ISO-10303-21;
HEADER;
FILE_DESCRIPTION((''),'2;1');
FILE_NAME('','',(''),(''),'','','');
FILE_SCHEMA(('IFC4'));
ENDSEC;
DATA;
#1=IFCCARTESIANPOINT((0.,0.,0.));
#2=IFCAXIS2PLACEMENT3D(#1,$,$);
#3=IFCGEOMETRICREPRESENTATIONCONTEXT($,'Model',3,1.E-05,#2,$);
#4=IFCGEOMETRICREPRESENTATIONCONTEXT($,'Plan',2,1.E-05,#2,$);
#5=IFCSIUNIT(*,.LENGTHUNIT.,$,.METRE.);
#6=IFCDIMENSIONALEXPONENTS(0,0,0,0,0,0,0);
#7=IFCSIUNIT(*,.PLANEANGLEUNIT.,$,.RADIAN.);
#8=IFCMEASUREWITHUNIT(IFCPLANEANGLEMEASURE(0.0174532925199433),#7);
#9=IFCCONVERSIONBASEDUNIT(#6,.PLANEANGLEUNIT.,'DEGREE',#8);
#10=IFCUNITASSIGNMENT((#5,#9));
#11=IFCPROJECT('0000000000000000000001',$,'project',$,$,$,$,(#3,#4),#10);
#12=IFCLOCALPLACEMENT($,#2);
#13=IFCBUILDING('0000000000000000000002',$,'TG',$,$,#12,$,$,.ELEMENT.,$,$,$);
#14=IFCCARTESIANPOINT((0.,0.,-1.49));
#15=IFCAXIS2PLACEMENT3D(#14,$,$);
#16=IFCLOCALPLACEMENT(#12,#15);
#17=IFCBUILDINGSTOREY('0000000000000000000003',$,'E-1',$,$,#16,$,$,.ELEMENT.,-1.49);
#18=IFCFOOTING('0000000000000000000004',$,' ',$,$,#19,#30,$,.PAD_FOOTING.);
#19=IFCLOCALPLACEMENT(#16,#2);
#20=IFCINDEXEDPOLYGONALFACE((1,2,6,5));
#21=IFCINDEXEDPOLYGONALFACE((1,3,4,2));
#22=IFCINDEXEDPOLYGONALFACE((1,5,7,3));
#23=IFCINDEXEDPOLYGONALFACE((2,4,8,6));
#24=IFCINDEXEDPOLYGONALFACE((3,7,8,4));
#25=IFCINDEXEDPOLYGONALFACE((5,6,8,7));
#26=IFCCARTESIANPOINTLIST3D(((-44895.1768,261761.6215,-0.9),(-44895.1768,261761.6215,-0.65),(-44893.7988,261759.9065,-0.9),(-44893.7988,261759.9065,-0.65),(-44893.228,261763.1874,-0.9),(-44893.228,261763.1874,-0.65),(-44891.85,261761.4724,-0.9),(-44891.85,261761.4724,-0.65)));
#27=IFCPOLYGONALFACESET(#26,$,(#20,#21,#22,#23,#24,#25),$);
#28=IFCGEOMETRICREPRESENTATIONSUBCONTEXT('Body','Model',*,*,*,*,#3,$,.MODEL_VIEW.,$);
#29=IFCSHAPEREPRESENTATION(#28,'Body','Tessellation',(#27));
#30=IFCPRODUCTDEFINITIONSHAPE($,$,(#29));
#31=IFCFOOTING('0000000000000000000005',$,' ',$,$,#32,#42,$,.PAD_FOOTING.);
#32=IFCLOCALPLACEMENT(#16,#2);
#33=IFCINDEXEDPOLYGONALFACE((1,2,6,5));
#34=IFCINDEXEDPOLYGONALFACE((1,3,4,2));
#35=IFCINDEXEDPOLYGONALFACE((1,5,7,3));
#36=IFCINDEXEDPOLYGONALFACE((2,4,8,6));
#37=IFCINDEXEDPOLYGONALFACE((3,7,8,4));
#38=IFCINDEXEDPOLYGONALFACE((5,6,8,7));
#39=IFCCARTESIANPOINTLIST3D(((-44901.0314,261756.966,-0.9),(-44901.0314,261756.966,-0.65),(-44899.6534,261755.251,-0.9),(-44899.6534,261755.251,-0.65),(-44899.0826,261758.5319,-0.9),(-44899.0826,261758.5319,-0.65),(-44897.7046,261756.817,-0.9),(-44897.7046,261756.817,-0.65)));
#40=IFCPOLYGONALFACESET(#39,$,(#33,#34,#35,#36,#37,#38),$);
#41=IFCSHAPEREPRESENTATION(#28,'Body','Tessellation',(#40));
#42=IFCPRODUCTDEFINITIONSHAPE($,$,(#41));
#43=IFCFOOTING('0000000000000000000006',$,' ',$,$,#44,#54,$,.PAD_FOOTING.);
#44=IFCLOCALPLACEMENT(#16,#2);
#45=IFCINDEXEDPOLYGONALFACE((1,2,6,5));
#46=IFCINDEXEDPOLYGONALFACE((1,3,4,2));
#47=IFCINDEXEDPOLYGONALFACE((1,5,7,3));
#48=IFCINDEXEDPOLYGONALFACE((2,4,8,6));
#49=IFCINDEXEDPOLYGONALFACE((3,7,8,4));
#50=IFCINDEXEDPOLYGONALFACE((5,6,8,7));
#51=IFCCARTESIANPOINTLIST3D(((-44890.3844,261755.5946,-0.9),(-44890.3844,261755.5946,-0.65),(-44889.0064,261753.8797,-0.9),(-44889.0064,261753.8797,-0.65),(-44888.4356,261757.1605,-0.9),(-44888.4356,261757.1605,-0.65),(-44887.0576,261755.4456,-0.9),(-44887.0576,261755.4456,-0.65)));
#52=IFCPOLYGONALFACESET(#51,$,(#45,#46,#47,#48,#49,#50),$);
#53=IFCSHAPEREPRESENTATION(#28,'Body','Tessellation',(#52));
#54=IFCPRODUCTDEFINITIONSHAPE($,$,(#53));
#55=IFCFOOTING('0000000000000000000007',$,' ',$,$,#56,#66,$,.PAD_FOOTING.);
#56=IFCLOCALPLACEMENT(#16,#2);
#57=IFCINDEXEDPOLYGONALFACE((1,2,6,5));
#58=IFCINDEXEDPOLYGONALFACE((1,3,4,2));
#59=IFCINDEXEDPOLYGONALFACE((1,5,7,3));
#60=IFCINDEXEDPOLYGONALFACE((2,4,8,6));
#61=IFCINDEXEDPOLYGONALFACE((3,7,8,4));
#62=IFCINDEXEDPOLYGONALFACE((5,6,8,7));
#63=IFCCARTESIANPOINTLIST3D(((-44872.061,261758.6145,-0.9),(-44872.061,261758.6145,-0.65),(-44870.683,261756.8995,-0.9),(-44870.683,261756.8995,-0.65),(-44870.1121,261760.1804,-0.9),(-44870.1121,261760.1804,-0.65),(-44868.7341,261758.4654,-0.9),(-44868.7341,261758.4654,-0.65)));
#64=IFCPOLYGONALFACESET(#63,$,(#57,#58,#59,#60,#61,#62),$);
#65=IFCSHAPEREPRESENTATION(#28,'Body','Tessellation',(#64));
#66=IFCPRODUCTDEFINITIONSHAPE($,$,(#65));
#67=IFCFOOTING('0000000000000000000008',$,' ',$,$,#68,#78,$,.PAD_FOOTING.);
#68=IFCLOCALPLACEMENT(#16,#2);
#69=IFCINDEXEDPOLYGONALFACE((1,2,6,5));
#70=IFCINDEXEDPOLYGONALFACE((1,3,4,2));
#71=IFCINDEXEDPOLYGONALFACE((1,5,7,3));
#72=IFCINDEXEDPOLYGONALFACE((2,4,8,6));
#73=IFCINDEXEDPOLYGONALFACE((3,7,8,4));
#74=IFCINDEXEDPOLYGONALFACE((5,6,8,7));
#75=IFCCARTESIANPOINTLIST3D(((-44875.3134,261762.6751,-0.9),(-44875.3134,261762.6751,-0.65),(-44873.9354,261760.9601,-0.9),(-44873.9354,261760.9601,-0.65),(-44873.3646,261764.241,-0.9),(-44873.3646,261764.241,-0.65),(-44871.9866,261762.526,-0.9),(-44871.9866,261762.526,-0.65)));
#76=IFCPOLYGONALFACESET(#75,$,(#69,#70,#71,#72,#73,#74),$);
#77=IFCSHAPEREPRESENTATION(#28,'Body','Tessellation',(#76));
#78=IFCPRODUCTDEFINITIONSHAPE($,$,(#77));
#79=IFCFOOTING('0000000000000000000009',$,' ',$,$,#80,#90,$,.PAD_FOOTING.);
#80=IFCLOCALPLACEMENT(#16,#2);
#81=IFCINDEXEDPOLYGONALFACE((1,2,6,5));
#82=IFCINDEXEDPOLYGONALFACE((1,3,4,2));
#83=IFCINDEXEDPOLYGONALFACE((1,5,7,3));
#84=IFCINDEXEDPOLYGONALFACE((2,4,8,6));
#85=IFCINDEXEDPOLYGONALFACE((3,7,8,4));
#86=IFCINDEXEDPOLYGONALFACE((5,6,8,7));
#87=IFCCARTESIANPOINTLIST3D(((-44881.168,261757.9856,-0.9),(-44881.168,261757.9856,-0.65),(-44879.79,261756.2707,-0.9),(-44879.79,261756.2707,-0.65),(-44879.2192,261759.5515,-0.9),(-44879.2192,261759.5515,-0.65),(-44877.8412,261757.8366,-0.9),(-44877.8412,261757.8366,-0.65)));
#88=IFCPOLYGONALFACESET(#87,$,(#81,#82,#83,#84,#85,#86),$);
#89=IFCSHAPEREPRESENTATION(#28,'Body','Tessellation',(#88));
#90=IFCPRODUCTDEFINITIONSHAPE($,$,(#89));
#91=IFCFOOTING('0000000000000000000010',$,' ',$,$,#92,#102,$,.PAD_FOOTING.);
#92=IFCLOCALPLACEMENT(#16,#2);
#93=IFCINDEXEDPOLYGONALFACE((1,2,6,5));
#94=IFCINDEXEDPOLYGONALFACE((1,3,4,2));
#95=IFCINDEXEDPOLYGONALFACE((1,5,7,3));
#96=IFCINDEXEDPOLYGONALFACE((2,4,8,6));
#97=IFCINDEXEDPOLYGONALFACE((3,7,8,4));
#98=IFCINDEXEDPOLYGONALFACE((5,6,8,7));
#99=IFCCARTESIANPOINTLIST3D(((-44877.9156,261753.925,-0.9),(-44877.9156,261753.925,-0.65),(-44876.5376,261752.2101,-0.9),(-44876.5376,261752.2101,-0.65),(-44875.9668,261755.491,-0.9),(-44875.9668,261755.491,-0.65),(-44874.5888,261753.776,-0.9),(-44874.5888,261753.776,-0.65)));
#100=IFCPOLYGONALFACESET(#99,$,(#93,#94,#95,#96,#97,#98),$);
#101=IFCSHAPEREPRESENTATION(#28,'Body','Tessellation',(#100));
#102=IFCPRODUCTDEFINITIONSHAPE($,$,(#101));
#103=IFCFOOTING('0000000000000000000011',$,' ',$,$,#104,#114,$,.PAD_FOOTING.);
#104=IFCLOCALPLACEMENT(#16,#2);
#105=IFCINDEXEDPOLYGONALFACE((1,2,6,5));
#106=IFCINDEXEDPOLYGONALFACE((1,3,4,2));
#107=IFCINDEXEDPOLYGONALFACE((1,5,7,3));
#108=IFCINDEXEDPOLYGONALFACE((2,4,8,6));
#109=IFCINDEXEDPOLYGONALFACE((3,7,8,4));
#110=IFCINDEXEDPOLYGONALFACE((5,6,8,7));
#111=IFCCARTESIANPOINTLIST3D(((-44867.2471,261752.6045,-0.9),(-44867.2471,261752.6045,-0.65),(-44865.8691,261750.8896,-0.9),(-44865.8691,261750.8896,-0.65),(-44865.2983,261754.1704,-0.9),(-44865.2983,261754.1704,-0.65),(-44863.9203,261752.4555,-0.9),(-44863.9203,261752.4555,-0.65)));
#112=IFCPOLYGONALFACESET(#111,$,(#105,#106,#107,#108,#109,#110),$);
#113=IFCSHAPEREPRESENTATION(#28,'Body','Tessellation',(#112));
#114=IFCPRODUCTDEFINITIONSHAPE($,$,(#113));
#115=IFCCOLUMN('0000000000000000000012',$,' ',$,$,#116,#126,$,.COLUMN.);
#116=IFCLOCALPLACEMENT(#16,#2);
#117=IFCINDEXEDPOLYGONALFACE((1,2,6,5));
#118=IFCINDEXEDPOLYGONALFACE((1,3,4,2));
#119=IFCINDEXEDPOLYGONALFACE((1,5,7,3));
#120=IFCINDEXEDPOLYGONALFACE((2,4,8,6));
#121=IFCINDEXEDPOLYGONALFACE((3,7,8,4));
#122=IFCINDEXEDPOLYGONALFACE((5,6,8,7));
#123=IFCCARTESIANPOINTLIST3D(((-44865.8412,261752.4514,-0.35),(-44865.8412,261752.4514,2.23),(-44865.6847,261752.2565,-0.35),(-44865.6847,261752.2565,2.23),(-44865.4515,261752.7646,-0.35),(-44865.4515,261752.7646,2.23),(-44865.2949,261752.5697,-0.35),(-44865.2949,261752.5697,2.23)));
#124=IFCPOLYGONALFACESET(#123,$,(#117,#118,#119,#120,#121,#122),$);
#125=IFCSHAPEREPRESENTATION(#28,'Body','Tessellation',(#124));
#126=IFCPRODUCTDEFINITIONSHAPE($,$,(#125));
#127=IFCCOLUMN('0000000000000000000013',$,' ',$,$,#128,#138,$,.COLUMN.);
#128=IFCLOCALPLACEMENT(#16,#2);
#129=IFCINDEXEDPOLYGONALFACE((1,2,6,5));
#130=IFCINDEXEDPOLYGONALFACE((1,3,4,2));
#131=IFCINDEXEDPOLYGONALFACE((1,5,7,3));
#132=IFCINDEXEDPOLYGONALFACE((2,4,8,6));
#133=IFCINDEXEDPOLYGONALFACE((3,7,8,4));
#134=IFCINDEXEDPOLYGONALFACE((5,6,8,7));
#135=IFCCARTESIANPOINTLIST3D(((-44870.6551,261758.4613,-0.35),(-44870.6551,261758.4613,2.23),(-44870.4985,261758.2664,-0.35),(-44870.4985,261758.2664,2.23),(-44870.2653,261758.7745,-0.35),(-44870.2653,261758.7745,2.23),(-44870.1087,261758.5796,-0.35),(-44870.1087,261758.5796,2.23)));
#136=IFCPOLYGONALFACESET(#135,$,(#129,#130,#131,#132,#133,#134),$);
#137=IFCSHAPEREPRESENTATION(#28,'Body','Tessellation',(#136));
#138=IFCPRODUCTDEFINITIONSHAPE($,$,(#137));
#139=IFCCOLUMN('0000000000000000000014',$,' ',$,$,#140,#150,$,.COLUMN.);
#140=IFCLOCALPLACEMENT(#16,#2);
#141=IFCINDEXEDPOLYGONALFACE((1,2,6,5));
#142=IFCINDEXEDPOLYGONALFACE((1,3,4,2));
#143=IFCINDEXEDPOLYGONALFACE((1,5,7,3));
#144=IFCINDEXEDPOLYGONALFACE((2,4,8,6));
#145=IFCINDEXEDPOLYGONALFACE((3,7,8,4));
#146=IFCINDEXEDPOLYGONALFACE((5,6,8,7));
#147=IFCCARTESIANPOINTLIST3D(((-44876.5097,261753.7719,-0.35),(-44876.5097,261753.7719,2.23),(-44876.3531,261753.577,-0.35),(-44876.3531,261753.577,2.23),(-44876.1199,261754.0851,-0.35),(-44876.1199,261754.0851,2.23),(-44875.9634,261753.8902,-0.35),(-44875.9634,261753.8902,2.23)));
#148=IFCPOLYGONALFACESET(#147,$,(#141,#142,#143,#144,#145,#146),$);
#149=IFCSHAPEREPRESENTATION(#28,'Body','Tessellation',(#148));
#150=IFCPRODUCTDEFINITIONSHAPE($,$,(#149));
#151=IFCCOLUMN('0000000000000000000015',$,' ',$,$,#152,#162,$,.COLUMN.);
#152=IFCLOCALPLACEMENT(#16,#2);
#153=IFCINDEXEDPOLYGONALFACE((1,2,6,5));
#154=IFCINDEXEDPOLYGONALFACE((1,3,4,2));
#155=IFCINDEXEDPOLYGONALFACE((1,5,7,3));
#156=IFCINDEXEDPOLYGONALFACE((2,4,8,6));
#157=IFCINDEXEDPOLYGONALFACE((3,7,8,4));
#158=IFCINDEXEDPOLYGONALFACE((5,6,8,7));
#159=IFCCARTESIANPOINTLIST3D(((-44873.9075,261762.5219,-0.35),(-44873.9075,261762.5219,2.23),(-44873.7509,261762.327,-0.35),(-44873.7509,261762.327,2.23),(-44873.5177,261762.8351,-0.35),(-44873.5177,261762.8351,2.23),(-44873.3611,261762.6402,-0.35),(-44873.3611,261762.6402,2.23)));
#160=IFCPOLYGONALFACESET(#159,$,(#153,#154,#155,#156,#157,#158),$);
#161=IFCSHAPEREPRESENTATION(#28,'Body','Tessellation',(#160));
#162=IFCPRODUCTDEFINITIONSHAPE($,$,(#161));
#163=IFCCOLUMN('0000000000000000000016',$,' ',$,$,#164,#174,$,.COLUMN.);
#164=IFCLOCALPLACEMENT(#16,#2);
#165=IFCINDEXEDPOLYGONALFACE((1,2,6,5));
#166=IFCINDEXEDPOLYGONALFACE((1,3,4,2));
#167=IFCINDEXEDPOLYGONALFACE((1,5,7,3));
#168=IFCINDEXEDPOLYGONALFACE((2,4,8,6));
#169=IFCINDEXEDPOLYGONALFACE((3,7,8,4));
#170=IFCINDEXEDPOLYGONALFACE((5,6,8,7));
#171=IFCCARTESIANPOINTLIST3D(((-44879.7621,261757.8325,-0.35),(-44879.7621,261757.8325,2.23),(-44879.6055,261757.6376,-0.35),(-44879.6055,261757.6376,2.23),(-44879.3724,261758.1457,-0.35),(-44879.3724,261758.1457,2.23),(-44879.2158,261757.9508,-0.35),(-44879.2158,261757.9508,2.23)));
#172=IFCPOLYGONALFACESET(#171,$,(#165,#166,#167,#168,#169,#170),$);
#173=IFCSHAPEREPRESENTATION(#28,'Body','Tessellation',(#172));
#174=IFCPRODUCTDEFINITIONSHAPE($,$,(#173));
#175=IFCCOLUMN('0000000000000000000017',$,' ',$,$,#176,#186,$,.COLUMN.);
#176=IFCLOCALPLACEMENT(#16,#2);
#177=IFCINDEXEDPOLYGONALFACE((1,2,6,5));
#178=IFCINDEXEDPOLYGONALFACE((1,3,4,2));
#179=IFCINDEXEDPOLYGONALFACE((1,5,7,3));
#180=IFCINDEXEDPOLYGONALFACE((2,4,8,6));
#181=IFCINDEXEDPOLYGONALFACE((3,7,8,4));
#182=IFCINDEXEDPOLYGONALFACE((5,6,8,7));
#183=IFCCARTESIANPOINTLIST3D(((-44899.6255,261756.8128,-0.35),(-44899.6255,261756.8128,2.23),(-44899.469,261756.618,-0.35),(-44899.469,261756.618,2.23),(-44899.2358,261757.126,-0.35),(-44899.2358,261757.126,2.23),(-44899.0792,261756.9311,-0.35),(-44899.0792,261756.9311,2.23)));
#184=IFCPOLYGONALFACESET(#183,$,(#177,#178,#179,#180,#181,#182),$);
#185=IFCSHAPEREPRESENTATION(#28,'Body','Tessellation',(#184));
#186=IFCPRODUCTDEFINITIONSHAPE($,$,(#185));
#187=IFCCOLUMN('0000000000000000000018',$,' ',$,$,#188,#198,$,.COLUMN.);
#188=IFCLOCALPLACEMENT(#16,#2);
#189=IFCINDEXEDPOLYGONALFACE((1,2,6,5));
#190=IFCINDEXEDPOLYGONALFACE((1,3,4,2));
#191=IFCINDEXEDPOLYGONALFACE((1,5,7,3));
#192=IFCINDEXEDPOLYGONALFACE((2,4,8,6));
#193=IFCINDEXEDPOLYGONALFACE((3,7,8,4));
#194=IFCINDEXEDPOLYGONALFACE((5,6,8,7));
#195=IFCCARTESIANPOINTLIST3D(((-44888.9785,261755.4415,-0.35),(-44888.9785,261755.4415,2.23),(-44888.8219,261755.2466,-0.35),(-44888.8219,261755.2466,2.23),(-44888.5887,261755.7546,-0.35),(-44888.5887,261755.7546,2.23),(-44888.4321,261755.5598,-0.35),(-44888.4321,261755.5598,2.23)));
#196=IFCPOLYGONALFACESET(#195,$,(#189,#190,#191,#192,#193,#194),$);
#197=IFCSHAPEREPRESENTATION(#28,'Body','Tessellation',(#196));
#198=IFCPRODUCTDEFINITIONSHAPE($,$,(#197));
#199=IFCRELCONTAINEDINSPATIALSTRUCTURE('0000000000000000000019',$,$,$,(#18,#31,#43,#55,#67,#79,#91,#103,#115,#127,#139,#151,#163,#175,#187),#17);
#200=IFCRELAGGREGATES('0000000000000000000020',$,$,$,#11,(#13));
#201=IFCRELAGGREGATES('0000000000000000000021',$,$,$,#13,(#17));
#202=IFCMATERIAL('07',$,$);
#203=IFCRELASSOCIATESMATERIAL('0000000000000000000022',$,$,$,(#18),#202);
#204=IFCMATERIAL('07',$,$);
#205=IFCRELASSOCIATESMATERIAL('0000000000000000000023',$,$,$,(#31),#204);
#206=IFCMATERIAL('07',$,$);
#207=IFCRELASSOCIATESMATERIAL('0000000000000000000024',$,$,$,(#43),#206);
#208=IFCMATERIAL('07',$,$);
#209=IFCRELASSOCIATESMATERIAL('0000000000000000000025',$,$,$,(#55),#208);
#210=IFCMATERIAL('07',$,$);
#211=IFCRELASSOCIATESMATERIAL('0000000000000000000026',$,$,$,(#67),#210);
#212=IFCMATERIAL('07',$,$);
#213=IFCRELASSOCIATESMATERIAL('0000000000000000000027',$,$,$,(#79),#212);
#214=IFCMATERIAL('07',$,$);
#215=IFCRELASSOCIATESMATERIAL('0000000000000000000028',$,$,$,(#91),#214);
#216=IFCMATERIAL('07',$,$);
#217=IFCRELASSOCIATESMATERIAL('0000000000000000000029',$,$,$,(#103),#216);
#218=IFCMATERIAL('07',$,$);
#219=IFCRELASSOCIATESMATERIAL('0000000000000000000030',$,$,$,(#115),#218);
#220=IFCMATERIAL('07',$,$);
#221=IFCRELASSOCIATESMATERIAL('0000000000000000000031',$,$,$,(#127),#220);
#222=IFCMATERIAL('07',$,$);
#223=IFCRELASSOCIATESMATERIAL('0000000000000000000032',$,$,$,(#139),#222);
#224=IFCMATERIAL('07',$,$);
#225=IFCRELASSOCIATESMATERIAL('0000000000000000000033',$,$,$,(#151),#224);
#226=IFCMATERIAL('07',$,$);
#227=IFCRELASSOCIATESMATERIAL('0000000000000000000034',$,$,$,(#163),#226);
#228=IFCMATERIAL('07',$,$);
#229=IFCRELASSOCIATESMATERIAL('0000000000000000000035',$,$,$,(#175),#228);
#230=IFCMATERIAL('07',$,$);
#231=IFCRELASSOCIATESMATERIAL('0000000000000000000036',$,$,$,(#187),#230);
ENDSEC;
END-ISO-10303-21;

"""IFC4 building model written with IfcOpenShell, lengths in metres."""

from ifc_helpers import new_model, entity, si_unit, converted_unit, frame, frame_2d, origin, origin_with_axes, place, context, subcontext, project, spatial, rectangle, extrude, material, element, save


model = new_model("IFC4")

# Units and contexts
model_context = context("Model", 3, precision=1e-05, world=origin())
plan_context = context("Plan", 2, precision=1e-05, world=origin())
body_context = subcontext(model_context, "Body", "Model", "MODEL_VIEW")
ifc_project = project(units=[si_unit("LENGTHUNIT", "METRE"), converted_unit("PLANEANGLEUNIT", "DEGREE", entity("IfcPlaneAngleMeasure", 0.0174532925199433), si_unit("PLANEANGLEUNIT", "RADIAN"), dimensions=[0, 0, 0, 0, 0, 0, 0])], contexts=[model_context, plan_context])

# Building, storey
building_placement = place(None, origin())
building = spatial("IfcBuilding", under=ifc_project, at=building_placement, Name="TG", CompositionType="ELEMENT")
storey_placement = place(building_placement, frame((0.0, 0.0, -1.49)))
storey = spatial("IfcBuildingStorey", under=building, at=storey_placement, Name="E-1", CompositionType="ELEMENT", Elevation=-1.49)

# Footings
ifc_material_1 = material(Name="07")
footing_1_placement = place(storey_placement, frame((-44895.1768, 261759.9065, -0.9)))
element("IfcFooting", 1, at=footing_1_placement, inside=storey, material=ifc_material_1, Name=" ", PredefinedType="PAD_FOOTING", context=body_context, shape_type="SweptSolid", body=[
    extrude(rectangle(XDim=2.5, YDim=2.2, at=frame_2d((0.2854, 1.6404), x_axis=(0.779531, 0.626364))), frame((1.378, 0.0, 0.0), z_axis=(0.0, 0.0, 1.0), x_axis=(1.0, 0.0, 0.0)), (0.0, 0.0, 1.0), 0.25),
])
ifc_material_2 = material(Name="07")
footing_2_placement = place(storey_placement, frame((-44901.0314, 261755.251, -0.9)))
element("IfcFooting", 2, at=footing_2_placement, inside=storey, material=ifc_material_2, Name=" ", PredefinedType="PAD_FOOTING", context=body_context, shape_type="SweptSolid", body=[
    extrude(rectangle(XDim=2.5, YDim=2.2, at=frame_2d((0.2854, 1.6404), x_axis=(0.779531, 0.626364))), frame((1.378, 0.0, 0.0), z_axis=(0.0, 0.0, 1.0), x_axis=(1.0, 0.0, 0.0)), (0.0, 0.0, 1.0), 0.25),
])
ifc_material_3 = material(Name="07")
footing_3_placement = place(storey_placement, frame((-44890.3844, 261753.8797, -0.9)))
element("IfcFooting", 3, at=footing_3_placement, inside=storey, material=ifc_material_3, Name=" ", PredefinedType="PAD_FOOTING", context=body_context, shape_type="SweptSolid", body=[
    extrude(rectangle(XDim=2.5, YDim=2.2, at=frame_2d((0.2854, 1.6404), x_axis=(0.779531, 0.626364))), frame((1.378, 0.0, 0.0), z_axis=(0.0, 0.0, 1.0), x_axis=(1.0, 0.0, 0.0)), (0.0, 0.0, 1.0), 0.25),
])
ifc_material_4 = material(Name="07")
footing_4_placement = place(storey_placement, frame((-44872.061, 261756.8995, -0.9)))
element("IfcFooting", 4, at=footing_4_placement, inside=storey, material=ifc_material_4, Name=" ", PredefinedType="PAD_FOOTING", context=body_context, shape_type="SweptSolid", body=[
    extrude(rectangle(XDim=2.5, YDim=2.2, at=frame_2d((0.2854, 1.6404), x_axis=(0.779531, 0.626364))), frame((1.378, 0.0, 0.0), z_axis=(0.0, 0.0, 1.0), x_axis=(1.0, 0.0, 0.0)), (0.0, 0.0, 1.0), 0.25),
])
ifc_material_5 = material(Name="07")
footing_5_placement = place(storey_placement, frame((-44875.3134, 261760.9601, -0.9)))
element("IfcFooting", 5, at=footing_5_placement, inside=storey, material=ifc_material_5, Name=" ", PredefinedType="PAD_FOOTING", context=body_context, shape_type="SweptSolid", body=[
    extrude(rectangle(XDim=2.5, YDim=2.2, at=frame_2d((0.2854, 1.6404), x_axis=(0.779531, 0.626364))), frame((1.378, 0.0, 0.0), z_axis=(0.0, 0.0, 1.0), x_axis=(1.0, 0.0, 0.0)), (0.0, 0.0, 1.0), 0.25),
])
ifc_material_6 = material(Name="07")
footing_6_placement = place(storey_placement, frame((-44881.168, 261756.2707, -0.9)))
element("IfcFooting", 6, at=footing_6_placement, inside=storey, material=ifc_material_6, Name=" ", PredefinedType="PAD_FOOTING", context=body_context, shape_type="SweptSolid", body=[
    extrude(rectangle(XDim=2.5, YDim=2.2, at=frame_2d((0.2854, 1.6404), x_axis=(0.779531, 0.626364))), frame((1.378, 0.0, 0.0), z_axis=(0.0, 0.0, 1.0), x_axis=(1.0, 0.0, 0.0)), (0.0, 0.0, 1.0), 0.25),
])
ifc_material_7 = material(Name="07")
footing_7_placement = place(storey_placement, frame((-44877.9156, 261752.2101, -0.9)))
element("IfcFooting", 7, at=footing_7_placement, inside=storey, material=ifc_material_7, Name=" ", PredefinedType="PAD_FOOTING", context=body_context, shape_type="SweptSolid", body=[
    extrude(rectangle(XDim=2.5, YDim=2.2, at=frame_2d((0.2854, 1.6404), x_axis=(0.779531, 0.626364))), frame((1.378, 0.0, 0.0), z_axis=(0.0, 0.0, 1.0), x_axis=(1.0, 0.0, 0.0)), (0.0, 0.0, 1.0), 0.25),
])
ifc_material_8 = material(Name="07")
footing_8_placement = place(storey_placement, frame((-44867.2471, 261750.8896, -0.9)))
element("IfcFooting", 8, at=footing_8_placement, inside=storey, material=ifc_material_8, Name=" ", PredefinedType="PAD_FOOTING", context=body_context, shape_type="SweptSolid", body=[
    extrude(rectangle(XDim=2.5, YDim=2.2, at=frame_2d((0.2854, 1.6404), x_axis=(0.779531, 0.626364))), frame((1.378, 0.0, 0.0), z_axis=(0.0, 0.0, 1.0), x_axis=(1.0, 0.0, 0.0)), (0.0, 0.0, 1.0), 0.25),
])

# Columns
ifc_material_9 = material(Name="07")
column_1_placement = place(storey_placement, frame((-44865.4515, 261752.7646, -0.35)))
element("IfcColumn", 9, at=column_1_placement, inside=storey, material=ifc_material_9, Name=" ", PredefinedType="COLUMN", context=body_context, shape_type="SweptSolid", body=[
    extrude(rectangle(XDim=0.5, YDim=0.25, at=frame_2d((-0.1166, -0.254), x_axis=(-0.779531, -0.626364))), origin_with_axes(), (0.0, 0.0, 1.0), 2.58),
])
ifc_material_10 = material(Name="07")
column_2_placement = place(storey_placement, frame((-44870.2653, 261758.7745, -0.35)))
element("IfcColumn", 10, at=column_2_placement, inside=storey, material=ifc_material_10, Name=" ", PredefinedType="COLUMN", context=body_context, shape_type="SweptSolid", body=[
    extrude(rectangle(XDim=0.5, YDim=0.25, at=frame_2d((-0.1166, -0.254), x_axis=(-0.779531, -0.626364))), origin_with_axes(), (0.0, 0.0, 1.0), 2.58),
])
ifc_material_11 = material(Name="07")
column_3_placement = place(storey_placement, frame((-44876.1199, 261754.0851, -0.35)))
element("IfcColumn", 11, at=column_3_placement, inside=storey, material=ifc_material_11, Name=" ", PredefinedType="COLUMN", context=body_context, shape_type="SweptSolid", body=[
    extrude(rectangle(XDim=0.5, YDim=0.25, at=frame_2d((-0.1166, -0.254), x_axis=(-0.779531, -0.626364))), origin_with_axes(), (0.0, 0.0, 1.0), 2.58),
])
ifc_material_12 = material(Name="07")
column_4_placement = place(storey_placement, frame((-44873.5177, 261762.8351, -0.35)))
element("IfcColumn", 12, at=column_4_placement, inside=storey, material=ifc_material_12, Name=" ", PredefinedType="COLUMN", context=body_context, shape_type="SweptSolid", body=[
    extrude(rectangle(XDim=0.5, YDim=0.25, at=frame_2d((-0.1166, -0.254), x_axis=(-0.779531, -0.626364))), origin_with_axes(), (0.0, 0.0, 1.0), 2.58),
])
ifc_material_13 = material(Name="07")
column_5_placement = place(storey_placement, frame((-44879.3724, 261758.1457, -0.35)))
element("IfcColumn", 13, at=column_5_placement, inside=storey, material=ifc_material_13, Name=" ", PredefinedType="COLUMN", context=body_context, shape_type="SweptSolid", body=[
    extrude(rectangle(XDim=0.5, YDim=0.25, at=frame_2d((-0.1166, -0.254), x_axis=(-0.779531, -0.626364))), origin_with_axes(), (0.0, 0.0, 1.0), 2.58),
])
ifc_material_14 = material(Name="07")
column_6_placement = place(storey_placement, frame((-44899.2358, 261757.126, -0.35)))
element("IfcColumn", 14, at=column_6_placement, inside=storey, material=ifc_material_14, Name=" ", PredefinedType="COLUMN", context=body_context, shape_type="SweptSolid", body=[
    extrude(rectangle(XDim=0.5, YDim=0.25, at=frame_2d((-0.1166, -0.254), x_axis=(-0.779531, -0.626364))), origin_with_axes(), (0.0, 0.0, 1.0), 2.58),
])
ifc_material_15 = material(Name="07")
column_7_placement = place(storey_placement, frame((-44888.5887, 261755.7546, -0.35)))
element("IfcColumn", 15, at=column_7_placement, inside=storey, material=ifc_material_15, Name=" ", PredefinedType="COLUMN", context=body_context, shape_type="SweptSolid", body=[
    extrude(rectangle(XDim=0.5, YDim=0.25, at=frame_2d((-0.1166, -0.254), x_axis=(-0.779531, -0.626364))), origin_with_axes(), (0.0, 0.0, 1.0), 2.58),
])

save(model, "model.ifc")
